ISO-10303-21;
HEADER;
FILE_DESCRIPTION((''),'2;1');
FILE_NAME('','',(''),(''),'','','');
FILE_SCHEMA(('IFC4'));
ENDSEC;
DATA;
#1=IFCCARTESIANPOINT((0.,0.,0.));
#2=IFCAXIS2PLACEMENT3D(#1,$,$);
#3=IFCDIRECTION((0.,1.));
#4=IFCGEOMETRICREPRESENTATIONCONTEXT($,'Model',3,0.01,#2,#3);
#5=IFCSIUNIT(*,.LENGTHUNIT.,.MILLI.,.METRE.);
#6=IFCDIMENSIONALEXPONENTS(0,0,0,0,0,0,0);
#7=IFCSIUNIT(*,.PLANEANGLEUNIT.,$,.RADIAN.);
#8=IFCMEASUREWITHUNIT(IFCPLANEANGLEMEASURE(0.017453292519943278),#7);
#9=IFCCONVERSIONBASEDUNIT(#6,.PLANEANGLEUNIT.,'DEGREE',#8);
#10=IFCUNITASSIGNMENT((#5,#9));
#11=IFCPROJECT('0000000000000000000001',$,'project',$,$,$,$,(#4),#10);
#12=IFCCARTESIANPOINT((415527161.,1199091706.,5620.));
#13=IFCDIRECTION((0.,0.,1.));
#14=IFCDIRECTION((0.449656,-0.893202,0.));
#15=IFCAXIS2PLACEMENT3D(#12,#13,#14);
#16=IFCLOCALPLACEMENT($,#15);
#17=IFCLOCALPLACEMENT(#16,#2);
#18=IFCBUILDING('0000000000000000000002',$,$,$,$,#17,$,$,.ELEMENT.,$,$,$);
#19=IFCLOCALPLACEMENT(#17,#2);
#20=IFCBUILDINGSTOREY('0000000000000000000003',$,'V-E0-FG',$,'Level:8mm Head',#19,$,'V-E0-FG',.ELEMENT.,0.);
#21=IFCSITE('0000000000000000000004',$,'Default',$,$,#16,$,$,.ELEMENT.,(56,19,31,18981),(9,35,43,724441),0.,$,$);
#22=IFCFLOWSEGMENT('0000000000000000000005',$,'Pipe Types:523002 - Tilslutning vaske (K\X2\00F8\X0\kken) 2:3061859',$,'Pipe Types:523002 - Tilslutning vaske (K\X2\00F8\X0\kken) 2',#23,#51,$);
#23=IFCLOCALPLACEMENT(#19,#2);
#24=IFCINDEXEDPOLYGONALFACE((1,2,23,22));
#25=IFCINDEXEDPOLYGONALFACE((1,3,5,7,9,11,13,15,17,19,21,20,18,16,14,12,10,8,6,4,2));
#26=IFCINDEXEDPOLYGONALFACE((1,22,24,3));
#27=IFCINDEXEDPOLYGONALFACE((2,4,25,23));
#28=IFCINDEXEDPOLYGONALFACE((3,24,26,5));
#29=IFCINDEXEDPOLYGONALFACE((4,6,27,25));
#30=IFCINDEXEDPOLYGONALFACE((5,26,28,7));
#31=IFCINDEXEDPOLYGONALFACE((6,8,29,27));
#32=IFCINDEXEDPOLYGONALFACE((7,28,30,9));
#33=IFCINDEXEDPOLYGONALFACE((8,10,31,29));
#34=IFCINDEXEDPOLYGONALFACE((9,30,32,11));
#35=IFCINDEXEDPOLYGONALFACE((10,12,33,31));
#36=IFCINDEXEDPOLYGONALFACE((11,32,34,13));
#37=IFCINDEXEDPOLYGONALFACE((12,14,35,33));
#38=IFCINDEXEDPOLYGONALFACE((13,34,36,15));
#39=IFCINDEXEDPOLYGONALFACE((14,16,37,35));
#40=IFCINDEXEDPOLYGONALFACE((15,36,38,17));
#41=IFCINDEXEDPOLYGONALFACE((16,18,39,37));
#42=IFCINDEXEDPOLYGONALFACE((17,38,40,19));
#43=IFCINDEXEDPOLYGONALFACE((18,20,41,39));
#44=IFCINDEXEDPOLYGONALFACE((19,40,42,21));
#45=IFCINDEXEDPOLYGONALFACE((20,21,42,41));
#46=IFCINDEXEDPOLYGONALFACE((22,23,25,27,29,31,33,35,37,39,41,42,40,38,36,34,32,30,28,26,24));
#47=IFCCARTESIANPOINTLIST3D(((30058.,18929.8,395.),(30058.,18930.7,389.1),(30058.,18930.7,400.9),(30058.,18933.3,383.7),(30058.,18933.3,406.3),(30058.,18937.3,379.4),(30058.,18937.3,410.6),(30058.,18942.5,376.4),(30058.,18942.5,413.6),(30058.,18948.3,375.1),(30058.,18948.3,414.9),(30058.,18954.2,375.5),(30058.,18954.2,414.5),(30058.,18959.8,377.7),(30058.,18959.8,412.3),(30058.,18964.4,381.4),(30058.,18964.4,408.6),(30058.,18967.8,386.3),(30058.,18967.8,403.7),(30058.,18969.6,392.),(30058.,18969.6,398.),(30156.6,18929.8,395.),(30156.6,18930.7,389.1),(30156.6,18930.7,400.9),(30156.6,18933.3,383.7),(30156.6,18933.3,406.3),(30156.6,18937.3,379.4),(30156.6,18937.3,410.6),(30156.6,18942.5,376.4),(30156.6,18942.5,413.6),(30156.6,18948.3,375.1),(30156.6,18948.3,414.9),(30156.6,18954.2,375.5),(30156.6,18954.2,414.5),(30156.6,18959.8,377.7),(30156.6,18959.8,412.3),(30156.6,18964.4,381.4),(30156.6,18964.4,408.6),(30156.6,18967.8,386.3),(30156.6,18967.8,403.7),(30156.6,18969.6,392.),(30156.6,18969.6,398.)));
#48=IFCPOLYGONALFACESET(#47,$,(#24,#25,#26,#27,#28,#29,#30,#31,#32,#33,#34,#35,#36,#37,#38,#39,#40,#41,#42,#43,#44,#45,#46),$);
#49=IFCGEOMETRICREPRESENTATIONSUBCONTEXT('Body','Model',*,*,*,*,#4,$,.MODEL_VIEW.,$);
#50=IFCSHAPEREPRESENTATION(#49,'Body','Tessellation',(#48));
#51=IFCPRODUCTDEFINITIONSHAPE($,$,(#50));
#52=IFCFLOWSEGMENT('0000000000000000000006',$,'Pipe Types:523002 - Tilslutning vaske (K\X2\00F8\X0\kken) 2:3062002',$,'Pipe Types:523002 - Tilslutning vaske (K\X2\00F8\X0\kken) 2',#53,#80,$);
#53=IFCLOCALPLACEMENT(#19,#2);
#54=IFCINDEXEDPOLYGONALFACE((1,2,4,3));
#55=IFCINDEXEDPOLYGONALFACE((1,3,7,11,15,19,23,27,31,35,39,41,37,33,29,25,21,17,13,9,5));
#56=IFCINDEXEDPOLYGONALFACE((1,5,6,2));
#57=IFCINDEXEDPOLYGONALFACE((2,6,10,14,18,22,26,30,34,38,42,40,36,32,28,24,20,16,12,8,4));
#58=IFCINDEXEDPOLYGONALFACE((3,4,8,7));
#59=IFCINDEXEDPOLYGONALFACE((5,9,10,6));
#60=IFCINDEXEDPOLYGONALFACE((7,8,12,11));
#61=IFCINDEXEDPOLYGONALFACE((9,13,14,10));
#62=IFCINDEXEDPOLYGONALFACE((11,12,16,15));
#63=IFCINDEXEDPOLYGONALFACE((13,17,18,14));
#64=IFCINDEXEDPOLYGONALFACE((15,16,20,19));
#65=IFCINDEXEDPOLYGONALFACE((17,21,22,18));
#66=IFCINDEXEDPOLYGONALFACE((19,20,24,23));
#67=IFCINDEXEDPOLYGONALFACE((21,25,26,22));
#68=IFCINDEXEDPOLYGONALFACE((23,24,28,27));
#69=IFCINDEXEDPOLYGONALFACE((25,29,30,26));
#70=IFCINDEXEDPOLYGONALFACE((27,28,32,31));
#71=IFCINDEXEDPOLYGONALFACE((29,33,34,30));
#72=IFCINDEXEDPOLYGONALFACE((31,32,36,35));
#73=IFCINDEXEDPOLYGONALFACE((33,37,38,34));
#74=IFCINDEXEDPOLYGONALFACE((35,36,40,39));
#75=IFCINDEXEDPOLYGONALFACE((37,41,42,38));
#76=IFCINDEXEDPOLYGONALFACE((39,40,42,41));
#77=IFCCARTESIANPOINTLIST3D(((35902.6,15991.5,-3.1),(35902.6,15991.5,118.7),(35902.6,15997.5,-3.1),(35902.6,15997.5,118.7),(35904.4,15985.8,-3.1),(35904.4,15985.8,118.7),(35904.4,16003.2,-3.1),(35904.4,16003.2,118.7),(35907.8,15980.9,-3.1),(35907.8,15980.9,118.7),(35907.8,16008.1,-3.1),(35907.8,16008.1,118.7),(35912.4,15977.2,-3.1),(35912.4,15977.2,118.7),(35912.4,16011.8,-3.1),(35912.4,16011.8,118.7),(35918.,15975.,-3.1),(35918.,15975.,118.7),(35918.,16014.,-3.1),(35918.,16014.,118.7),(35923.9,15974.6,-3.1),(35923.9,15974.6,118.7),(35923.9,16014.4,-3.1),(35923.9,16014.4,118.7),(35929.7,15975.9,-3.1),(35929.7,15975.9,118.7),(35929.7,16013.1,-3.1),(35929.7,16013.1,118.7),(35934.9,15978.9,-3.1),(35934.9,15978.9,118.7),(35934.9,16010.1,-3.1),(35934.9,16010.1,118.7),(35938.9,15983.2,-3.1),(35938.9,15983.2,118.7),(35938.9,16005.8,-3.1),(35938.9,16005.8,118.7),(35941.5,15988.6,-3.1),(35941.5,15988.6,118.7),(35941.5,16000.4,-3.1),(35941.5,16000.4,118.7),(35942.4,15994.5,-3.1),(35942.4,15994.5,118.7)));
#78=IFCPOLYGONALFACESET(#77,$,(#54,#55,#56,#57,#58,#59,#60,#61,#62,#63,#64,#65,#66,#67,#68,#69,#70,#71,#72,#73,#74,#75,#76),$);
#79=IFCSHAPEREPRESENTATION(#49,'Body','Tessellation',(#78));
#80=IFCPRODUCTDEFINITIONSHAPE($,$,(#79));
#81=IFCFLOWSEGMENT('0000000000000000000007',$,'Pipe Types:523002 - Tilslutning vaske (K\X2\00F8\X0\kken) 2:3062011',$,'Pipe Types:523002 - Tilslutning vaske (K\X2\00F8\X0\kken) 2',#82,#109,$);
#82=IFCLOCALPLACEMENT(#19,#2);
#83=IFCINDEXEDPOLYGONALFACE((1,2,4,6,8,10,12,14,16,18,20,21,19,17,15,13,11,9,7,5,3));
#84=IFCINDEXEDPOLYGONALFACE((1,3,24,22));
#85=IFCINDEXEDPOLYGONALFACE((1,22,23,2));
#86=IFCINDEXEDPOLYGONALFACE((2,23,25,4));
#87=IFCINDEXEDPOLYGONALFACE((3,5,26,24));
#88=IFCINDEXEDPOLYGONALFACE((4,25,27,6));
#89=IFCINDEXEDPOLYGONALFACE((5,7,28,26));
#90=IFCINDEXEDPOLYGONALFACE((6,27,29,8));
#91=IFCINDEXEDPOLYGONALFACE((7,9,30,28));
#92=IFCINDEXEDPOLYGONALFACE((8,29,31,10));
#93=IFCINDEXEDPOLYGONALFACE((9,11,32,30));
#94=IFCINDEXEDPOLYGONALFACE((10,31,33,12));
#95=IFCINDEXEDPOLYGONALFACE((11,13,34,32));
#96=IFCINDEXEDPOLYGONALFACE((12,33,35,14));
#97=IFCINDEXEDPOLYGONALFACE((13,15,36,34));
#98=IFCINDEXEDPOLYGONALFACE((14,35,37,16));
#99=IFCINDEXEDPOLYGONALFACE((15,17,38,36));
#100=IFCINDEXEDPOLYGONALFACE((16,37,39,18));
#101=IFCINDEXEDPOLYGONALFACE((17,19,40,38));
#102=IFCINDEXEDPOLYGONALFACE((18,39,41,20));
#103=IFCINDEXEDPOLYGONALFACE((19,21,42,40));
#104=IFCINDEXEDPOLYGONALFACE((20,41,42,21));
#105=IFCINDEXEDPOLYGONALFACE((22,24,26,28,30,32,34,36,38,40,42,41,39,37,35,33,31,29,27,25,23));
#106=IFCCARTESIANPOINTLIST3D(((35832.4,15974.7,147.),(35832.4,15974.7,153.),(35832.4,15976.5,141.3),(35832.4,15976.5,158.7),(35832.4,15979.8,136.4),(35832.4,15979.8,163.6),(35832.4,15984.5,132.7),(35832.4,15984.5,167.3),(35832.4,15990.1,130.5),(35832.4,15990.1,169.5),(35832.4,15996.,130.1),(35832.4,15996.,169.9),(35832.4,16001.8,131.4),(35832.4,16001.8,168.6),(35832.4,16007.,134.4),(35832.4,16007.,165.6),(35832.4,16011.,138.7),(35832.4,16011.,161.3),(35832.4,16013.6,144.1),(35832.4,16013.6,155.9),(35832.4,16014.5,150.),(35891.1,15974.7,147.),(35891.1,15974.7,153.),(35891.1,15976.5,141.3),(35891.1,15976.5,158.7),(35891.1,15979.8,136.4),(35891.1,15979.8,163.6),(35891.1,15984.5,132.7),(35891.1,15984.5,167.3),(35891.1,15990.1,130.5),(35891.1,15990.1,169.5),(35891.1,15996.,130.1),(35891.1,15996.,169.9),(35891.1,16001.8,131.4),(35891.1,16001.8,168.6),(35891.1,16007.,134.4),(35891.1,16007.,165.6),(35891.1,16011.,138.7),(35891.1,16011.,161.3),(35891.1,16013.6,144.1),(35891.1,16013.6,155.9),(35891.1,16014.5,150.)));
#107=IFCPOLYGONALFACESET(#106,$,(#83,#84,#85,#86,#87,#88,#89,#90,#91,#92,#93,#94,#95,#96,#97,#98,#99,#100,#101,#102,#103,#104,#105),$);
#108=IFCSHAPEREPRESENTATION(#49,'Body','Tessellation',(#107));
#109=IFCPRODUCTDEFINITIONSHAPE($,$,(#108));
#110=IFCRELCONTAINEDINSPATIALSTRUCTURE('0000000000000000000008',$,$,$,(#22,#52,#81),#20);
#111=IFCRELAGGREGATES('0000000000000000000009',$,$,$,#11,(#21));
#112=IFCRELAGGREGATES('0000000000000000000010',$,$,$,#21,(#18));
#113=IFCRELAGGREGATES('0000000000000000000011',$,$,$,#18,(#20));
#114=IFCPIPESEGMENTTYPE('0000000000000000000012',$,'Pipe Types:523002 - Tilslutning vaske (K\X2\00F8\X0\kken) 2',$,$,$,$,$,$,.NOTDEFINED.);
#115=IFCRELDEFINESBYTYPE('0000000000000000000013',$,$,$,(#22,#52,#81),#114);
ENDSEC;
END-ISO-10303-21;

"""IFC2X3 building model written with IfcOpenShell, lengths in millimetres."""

from ifc_helpers import new_model, entity, si_unit, converted_unit, direction, frame, frame_2d, origin, origin_2d_with_axis, place, context, subcontext, project, spatial, circle, extrude, type_object, element, save


model = new_model("IFC2X3")

# Units and contexts
model_context = context("Model", 3, precision=0.01, world=origin(), true_north=direction((0.0, 1.0)))
body_context = subcontext(model_context, "Body", "Model", "MODEL_VIEW")
ifc_project = project(units=[si_unit("LENGTHUNIT", "METRE", prefix="MILLI"), converted_unit("PLANEANGLEUNIT", "DEGREE", entity("IfcPlaneAngleMeasure", 0.017453292519943278), si_unit("PLANEANGLEUNIT", "RADIAN"), dimensions=[0, 0, 0, 0, 0, 0, 0])], contexts=[model_context])

# Site, building, storey
site_placement = place(None, frame((415527161.0, 1199091706.0, 5620.0), z_axis=(0.0, 0.0, 1.0), x_axis=(0.449656, -0.893202, 0.0)))
site = spatial("IfcSite", under=ifc_project, at=site_placement, Name="Default", CompositionType="ELEMENT", RefLatitude=(56, 19, 31, 18981), RefLongitude=(9, 35, 43, 724441), RefElevation=0.0)
building_placement = place(site_placement, origin())
building = spatial("IfcBuilding", under=site, at=building_placement, CompositionType="ELEMENT")
storey_placement = place(building_placement, origin())
storey = spatial("IfcBuildingStorey", under=building, at=storey_placement, Name="V-E0-FG", ObjectType="Level:8mm Head", LongName="V-E0-FG", CompositionType="ELEMENT", Elevation=0.0)

# Flow segments
pipe_segment_type_1 = type_object("IfcPipeSegmentType", Name="Pipe Types:523002 - Tilslutning vaske (Køkken) 2", PredefinedType="NOTDEFINED")
flow_segment_1_placement = place(storey_placement, origin())
element("IfcFlowSegment", 1, at=flow_segment_1_placement, inside=storey, type_object=pipe_segment_type_1, Name="Pipe Types:523002 - Tilslutning vaske (Køkken) 2:3061859", ObjectType="Pipe Types:523002 - Tilslutning vaske (Køkken) 2", context=body_context, shape_type="SweptSolid", body=[
    extrude(circle(Radius=20.0, at=frame_2d((0.0, 0.0), x_axis=(1.0, 0.0))), frame((30058.0, 18949.8, 395.0), z_axis=(1.0, 0.0, 0.0), x_axis=(0.0, -1.0, 0.0)), (0.0, 0.0, 1.0), 98.7),
])
flow_segment_2_placement = place(storey_placement, origin())
element("IfcFlowSegment", 2, at=flow_segment_2_placement, inside=storey, type_object=pipe_segment_type_1, Name="Pipe Types:523002 - Tilslutning vaske (Køkken) 2:3062002", ObjectType="Pipe Types:523002 - Tilslutning vaske (Køkken) 2", context=body_context, shape_type="SweptSolid", body=[
    extrude(circle(Radius=20.0, at=origin_2d_with_axis()), frame((35922.4, 15994.5, -3.1)), (0.0, 0.0, 1.0), 121.7),
])
flow_segment_3_placement = place(storey_placement, origin())
element("IfcFlowSegment", 3, at=flow_segment_3_placement, inside=storey, type_object=pipe_segment_type_1, Name="Pipe Types:523002 - Tilslutning vaske (Køkken) 2:3062011", ObjectType="Pipe Types:523002 - Tilslutning vaske (Køkken) 2", context=body_context, shape_type="SweptSolid", body=[
    extrude(circle(Radius=20.0, at=frame_2d((0.0, 0.0), x_axis=(1.0, 0.0))), frame((35832.4, 15994.5, 150.0), z_axis=(1.0, 0.0, 0.0), x_axis=(0.0, 1.0, 0.0)), (0.0, 0.0, 1.0), 58.7),
])

save(model, "model.ifc")
